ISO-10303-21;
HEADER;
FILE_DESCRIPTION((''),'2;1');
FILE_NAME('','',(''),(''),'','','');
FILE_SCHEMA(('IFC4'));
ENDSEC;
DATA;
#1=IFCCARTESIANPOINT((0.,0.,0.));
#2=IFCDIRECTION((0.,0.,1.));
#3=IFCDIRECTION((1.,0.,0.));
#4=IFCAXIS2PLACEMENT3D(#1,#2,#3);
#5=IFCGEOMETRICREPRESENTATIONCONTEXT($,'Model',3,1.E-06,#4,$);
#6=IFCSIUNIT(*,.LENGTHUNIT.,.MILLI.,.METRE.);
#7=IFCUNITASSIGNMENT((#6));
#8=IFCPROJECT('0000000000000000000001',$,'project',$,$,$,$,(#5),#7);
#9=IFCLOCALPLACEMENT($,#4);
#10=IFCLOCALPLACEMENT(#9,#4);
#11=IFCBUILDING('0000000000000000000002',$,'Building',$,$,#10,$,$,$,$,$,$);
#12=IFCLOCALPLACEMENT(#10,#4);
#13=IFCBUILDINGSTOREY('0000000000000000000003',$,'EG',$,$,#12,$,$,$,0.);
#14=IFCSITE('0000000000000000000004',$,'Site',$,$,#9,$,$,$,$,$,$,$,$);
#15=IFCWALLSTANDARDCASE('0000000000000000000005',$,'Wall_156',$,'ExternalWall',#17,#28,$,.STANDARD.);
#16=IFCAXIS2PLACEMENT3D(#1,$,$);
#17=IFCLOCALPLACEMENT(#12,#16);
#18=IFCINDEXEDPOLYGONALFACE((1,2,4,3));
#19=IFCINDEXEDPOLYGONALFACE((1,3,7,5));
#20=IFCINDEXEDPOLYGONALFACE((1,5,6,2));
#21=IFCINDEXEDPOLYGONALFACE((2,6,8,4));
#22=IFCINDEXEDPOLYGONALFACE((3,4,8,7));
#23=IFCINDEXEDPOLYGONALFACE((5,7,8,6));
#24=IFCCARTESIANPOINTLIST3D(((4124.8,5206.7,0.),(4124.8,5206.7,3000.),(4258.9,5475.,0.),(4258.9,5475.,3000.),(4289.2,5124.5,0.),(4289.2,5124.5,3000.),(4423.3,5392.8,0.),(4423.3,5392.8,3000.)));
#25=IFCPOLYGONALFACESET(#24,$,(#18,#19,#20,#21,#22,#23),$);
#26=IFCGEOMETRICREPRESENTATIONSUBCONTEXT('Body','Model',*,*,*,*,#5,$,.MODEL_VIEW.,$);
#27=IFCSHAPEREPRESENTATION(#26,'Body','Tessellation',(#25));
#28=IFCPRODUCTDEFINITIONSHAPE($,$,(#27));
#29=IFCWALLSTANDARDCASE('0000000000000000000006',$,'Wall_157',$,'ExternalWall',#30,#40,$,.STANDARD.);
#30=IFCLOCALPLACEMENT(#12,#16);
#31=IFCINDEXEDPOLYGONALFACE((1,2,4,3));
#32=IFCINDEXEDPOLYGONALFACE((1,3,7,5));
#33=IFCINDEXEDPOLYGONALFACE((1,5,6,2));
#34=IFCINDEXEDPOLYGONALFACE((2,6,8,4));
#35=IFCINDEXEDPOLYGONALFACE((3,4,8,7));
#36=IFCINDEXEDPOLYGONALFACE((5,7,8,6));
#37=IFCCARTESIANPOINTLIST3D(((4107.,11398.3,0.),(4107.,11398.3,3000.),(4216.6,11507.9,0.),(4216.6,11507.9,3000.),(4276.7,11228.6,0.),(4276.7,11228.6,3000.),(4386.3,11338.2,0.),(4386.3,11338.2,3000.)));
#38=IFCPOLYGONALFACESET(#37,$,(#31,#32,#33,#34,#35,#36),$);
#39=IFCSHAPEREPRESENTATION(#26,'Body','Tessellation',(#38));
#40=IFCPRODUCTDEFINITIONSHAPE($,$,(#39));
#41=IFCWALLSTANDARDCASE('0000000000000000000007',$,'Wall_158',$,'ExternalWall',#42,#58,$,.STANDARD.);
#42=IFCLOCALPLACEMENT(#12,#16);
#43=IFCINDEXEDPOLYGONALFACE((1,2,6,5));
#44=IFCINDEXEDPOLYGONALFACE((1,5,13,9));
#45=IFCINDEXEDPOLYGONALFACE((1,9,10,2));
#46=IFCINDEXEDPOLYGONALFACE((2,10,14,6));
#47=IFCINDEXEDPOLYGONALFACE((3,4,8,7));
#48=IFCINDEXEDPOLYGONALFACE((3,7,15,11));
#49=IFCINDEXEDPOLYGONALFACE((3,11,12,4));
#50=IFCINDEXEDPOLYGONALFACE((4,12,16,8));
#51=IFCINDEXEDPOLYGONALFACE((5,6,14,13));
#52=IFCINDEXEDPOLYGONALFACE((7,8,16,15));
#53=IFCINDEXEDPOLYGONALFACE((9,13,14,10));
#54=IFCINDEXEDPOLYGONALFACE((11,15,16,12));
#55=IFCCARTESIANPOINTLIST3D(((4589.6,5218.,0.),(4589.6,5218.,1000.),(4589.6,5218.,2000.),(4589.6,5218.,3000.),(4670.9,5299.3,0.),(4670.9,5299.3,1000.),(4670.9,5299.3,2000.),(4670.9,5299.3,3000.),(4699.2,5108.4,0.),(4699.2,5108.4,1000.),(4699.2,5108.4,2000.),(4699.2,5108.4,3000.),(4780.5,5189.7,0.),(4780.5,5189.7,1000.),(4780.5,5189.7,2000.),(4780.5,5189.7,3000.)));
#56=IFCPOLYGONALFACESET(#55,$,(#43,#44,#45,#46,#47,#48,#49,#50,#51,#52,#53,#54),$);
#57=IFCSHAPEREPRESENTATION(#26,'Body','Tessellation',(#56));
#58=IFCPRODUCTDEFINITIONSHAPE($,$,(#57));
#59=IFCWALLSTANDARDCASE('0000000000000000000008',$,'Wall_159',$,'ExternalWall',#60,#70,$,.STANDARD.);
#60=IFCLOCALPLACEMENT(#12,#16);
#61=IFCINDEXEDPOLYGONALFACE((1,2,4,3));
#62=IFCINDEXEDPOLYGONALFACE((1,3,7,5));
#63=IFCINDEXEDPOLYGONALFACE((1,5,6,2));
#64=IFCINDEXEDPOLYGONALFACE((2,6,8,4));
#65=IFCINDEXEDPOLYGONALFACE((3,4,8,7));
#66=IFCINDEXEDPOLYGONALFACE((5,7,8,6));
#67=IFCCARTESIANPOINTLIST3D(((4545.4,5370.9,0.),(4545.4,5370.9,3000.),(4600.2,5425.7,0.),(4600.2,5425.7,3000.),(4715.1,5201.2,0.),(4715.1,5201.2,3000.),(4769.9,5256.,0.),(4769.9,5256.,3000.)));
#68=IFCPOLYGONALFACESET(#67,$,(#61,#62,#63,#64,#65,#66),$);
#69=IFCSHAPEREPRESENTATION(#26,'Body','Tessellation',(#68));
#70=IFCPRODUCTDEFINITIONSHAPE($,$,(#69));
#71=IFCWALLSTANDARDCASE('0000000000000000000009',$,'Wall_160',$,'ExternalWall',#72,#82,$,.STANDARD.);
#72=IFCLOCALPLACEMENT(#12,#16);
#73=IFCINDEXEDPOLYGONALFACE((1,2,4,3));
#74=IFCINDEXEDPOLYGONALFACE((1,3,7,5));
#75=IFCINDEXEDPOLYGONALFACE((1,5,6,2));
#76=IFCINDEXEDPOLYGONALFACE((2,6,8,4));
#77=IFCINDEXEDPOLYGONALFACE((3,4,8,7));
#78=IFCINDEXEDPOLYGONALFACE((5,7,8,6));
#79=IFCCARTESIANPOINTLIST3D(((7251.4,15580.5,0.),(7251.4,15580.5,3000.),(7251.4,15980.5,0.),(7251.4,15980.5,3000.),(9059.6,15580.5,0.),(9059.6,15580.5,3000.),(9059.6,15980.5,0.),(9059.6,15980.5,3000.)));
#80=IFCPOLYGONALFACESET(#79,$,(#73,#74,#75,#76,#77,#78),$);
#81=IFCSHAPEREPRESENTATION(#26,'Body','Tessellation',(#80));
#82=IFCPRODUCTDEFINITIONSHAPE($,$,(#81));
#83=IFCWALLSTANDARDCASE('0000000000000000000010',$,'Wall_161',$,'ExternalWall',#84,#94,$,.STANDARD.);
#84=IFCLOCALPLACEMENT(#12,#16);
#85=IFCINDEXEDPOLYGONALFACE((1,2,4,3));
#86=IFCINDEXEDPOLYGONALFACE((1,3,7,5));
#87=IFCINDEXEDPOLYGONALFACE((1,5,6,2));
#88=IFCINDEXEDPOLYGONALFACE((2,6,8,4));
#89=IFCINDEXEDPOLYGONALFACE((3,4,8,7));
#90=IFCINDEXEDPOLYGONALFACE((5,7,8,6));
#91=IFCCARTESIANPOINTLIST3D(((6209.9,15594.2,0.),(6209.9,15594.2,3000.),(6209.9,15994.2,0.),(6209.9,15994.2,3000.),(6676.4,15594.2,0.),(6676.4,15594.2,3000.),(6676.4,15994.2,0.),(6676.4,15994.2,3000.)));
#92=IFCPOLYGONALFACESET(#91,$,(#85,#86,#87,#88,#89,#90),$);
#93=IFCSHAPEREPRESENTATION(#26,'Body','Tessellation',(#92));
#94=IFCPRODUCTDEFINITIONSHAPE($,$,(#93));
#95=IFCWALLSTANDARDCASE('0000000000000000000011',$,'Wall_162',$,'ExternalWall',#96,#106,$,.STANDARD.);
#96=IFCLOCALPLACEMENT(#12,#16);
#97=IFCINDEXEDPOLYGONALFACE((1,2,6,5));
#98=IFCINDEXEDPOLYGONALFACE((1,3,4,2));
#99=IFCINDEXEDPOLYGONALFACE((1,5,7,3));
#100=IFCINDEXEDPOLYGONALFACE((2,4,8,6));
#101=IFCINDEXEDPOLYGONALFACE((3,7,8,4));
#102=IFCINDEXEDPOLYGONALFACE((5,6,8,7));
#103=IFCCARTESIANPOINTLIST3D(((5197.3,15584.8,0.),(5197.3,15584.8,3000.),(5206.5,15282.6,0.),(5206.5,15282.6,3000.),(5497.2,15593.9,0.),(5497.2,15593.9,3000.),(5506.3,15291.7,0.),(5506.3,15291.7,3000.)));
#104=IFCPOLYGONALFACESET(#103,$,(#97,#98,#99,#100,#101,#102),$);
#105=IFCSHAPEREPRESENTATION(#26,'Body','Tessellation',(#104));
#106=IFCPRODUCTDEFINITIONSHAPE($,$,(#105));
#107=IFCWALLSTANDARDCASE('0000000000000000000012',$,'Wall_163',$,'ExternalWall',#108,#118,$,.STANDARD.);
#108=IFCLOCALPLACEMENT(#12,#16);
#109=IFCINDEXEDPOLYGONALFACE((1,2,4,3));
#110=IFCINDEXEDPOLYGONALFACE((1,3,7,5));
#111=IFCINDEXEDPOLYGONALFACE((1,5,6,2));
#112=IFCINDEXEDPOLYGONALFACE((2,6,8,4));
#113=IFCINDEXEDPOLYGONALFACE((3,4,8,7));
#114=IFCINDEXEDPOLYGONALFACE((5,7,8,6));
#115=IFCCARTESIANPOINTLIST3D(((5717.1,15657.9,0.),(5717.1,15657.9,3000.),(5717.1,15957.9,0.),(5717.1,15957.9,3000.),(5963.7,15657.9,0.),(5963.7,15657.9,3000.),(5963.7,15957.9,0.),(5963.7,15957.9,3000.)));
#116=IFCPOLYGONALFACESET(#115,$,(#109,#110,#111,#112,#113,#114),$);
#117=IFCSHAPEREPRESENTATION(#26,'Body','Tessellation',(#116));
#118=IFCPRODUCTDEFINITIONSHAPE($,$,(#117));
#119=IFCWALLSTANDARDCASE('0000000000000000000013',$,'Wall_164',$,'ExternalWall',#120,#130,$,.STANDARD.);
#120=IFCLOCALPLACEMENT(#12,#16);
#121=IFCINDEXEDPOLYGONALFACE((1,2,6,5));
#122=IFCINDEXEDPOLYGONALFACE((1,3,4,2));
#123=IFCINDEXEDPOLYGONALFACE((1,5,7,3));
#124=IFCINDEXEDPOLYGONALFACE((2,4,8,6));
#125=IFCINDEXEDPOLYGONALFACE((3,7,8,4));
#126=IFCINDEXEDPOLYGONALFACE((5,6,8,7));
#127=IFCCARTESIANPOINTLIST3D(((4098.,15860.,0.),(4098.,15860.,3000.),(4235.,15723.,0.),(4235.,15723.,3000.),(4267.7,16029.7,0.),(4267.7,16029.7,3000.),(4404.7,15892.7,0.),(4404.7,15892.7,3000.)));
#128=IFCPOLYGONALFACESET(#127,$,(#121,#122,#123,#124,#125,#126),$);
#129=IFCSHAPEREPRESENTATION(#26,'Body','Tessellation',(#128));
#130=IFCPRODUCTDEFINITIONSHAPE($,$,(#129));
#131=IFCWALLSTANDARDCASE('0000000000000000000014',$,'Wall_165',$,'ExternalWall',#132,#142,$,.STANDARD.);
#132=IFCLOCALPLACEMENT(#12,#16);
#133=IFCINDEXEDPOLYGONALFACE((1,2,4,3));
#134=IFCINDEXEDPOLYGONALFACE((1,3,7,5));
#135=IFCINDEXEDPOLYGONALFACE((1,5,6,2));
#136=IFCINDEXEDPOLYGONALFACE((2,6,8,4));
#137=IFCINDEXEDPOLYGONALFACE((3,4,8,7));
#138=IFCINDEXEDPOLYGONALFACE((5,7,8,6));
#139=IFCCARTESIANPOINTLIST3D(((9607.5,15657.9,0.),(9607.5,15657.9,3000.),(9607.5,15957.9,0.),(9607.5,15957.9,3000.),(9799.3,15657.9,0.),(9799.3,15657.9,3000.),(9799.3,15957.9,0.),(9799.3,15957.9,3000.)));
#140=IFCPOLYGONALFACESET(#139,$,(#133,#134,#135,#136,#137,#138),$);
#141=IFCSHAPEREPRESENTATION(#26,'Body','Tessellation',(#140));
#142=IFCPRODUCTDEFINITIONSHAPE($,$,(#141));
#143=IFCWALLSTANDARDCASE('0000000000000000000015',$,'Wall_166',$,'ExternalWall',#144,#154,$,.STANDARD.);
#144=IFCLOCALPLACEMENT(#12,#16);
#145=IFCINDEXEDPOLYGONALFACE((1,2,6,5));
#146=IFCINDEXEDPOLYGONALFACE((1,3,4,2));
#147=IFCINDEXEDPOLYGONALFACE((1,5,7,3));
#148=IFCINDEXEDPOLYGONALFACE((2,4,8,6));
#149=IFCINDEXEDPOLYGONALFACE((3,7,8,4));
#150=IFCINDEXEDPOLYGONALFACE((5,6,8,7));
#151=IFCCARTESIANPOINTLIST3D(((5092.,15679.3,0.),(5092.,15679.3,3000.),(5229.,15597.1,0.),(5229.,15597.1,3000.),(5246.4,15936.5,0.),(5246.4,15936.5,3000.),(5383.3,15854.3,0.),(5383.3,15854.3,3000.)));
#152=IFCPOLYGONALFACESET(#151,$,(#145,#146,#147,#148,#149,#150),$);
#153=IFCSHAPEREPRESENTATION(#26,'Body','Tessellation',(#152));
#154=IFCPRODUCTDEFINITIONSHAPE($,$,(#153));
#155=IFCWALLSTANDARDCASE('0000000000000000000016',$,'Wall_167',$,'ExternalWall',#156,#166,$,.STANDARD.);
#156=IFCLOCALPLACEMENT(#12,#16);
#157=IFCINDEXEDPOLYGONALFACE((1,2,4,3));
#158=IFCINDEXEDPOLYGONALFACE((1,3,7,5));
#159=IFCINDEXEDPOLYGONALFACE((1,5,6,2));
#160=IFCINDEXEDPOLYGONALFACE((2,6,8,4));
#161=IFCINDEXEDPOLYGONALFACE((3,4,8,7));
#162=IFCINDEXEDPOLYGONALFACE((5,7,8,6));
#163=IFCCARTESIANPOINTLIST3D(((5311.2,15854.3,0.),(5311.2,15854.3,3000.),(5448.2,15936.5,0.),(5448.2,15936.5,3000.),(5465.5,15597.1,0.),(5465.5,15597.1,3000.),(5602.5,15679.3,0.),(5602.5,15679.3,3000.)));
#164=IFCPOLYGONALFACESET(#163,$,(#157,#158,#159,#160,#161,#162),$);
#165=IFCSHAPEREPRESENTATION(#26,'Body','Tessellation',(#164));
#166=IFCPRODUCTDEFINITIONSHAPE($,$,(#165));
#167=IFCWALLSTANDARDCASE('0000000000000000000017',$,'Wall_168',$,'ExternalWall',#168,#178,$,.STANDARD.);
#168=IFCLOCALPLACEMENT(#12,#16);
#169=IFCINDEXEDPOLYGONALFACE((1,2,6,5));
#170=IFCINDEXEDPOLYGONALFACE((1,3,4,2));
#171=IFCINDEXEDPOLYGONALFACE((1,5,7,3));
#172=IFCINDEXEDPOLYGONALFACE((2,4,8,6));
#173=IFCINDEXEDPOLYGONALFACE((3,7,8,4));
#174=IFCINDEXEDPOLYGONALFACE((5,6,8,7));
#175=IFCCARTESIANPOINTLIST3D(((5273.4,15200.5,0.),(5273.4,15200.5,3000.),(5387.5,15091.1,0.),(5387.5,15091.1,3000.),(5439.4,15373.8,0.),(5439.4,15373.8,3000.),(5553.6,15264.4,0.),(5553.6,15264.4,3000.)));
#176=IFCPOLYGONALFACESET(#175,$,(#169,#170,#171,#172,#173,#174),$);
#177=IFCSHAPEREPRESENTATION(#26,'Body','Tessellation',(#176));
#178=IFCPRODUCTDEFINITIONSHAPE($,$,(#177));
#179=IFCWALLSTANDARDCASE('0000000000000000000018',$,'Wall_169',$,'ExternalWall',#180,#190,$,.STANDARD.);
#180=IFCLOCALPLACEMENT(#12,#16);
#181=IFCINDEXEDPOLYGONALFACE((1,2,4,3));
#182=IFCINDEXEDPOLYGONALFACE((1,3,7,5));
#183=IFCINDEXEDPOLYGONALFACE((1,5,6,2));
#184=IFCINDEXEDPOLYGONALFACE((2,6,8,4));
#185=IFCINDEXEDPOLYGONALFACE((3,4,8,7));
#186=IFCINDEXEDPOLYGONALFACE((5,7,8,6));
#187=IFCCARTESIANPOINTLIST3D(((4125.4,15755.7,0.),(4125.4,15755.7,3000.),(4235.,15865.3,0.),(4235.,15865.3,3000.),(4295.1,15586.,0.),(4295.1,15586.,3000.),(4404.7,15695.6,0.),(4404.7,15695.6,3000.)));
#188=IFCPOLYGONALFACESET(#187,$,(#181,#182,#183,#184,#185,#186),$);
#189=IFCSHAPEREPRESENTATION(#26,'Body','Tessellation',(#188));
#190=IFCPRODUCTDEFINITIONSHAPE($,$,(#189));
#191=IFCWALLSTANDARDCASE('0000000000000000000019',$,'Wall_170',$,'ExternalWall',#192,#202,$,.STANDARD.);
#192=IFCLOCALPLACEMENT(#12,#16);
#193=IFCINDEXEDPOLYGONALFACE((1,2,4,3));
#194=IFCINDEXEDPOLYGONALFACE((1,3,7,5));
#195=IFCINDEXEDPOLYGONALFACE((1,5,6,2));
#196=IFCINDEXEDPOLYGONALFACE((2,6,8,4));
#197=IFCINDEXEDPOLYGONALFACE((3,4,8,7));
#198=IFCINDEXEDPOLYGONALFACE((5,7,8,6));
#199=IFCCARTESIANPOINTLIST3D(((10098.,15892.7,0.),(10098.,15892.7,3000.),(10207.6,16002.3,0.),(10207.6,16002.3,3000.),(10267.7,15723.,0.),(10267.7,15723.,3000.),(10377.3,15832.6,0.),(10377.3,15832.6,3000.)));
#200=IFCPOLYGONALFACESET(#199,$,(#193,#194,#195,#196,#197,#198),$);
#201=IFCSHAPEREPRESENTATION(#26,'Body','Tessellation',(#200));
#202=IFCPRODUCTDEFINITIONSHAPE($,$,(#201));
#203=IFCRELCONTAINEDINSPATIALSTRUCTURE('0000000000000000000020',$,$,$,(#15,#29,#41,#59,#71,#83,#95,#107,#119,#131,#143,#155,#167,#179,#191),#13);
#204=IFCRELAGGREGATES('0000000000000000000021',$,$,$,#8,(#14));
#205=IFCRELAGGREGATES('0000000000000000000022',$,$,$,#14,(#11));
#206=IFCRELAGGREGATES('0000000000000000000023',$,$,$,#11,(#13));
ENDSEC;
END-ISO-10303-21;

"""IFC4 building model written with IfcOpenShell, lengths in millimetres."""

from ifc_helpers import new_model, si_unit, frame, origin_with_axes, place, context, subcontext, project, spatial, rectangle, extrude, element, save


model = new_model("IFC4")

# Units and contexts
model_context = context("Model", 3, precision=1e-06, world=origin_with_axes())
body_context = subcontext(model_context, "Body", "Model", "MODEL_VIEW")
ifc_project = project(units=[si_unit("LENGTHUNIT", "METRE", prefix="MILLI")], contexts=[model_context])

# Site, building, storey
site_placement = place(None, origin_with_axes())
site = spatial("IfcSite", under=ifc_project, at=site_placement, Name="Site")
building_placement = place(site_placement, origin_with_axes())
building = spatial("IfcBuilding", under=site, at=building_placement, Name="Building")
storey_placement = place(building_placement, origin_with_axes())
storey = spatial("IfcBuildingStorey", under=building, at=storey_placement, Name="EG", Elevation=0.0)

# Walls
wall_1_placement = place(storey_placement, origin_with_axes())
element("IfcWallStandardCase", 1, at=wall_1_placement, inside=storey, Name="Wall_156", ObjectType="ExternalWall", PredefinedType="STANDARD", context=body_context, shape_type="SweptSolid", body=[
    extrude(rectangle(XDim=183.8, YDim=300.0), frame((4274.1, 5299.7, 0.0), z_axis=(0.0, 0.0, 1.0), x_axis=(-0.894427, 0.447214, 0.0)), (0.0, 0.0, 1.0), 3000.0),
])
wall_2_placement = place(storey_placement, origin_with_axes())
element("IfcWallStandardCase", 2, at=wall_2_placement, inside=storey, Name="Wall_157", ObjectType="ExternalWall", PredefinedType="STANDARD", context=body_context, shape_type="SweptSolid", body=[
    extrude(rectangle(XDim=155.0, YDim=240.0), frame((4246.7, 11368.2, 0.0), z_axis=(0.0, 0.0, 1.0), x_axis=(0.707107, 0.707107, 0.0)), (0.0, 0.0, 1.0), 3000.0),
])

# Wall, opening
wall_3_placement = place(storey_placement, origin_with_axes())
wall_3 = element("IfcWallStandardCase", 3, at=wall_3_placement, inside=storey, Name="Wall_158", ObjectType="ExternalWall", PredefinedType="STANDARD", context=body_context, shape_type="SweptSolid", body=[
    extrude(rectangle(XDim=155.0, YDim=115.0), frame((4685.0, 5203.9, 0.0), z_axis=(0.0, 0.0, 1.0), x_axis=(0.707107, -0.707107, 0.0)), (0.0, 0.0, 1.0), 3000.0),
])
opening_1_placement = place(wall_3_placement, origin_with_axes())
element("IfcOpeningElement", 4, at=opening_1_placement, inside=storey, cuts=wall_3, context=body_context, shape_type="SweptSolid", body=[
    extrude(rectangle(XDim=2418.9, YDim=115.0), frame((5473.2, 4415.6, 1000.0), z_axis=(0.0, 0.0, 1.0), x_axis=(0.707107, -0.707107, 0.0)), (0.0, 0.0, 1.0), 1000.0),
])

# Walls
wall_4_placement = place(storey_placement, origin_with_axes())
element("IfcWallStandardCase", 5, at=wall_4_placement, inside=storey, Name="Wall_159", ObjectType="ExternalWall", PredefinedType="STANDARD", context=body_context, shape_type="SweptSolid", body=[
    extrude(rectangle(XDim=77.5, YDim=240.0), frame((4657.6, 5313.4, 0.0), z_axis=(0.0, 0.0, 1.0), x_axis=(0.707107, 0.707107, 0.0)), (0.0, 0.0, 1.0), 3000.0),
])
wall_5_placement = place(storey_placement, origin_with_axes())
element("IfcWallStandardCase", 6, at=wall_5_placement, inside=storey, Name="Wall_160", ObjectType="ExternalWall", PredefinedType="STANDARD", context=body_context, shape_type="SweptSolid", body=[
    extrude(rectangle(XDim=1808.2, YDim=400.0), frame((8155.5, 15780.5, 0.0), z_axis=(0.0, 0.0, 1.0), x_axis=(1.0, 0.0, 0.0)), (0.0, 0.0, 1.0), 3000.0),
])
wall_6_placement = place(storey_placement, origin_with_axes())
element("IfcWallStandardCase", 7, at=wall_6_placement, inside=storey, Name="Wall_161", ObjectType="ExternalWall", PredefinedType="STANDARD", context=body_context, shape_type="SweptSolid", body=[
    extrude(rectangle(XDim=466.6, YDim=400.0), frame((6443.2, 15794.2, 0.0), z_axis=(0.0, 0.0, 1.0), x_axis=(1.0, 0.0, 0.0)), (0.0, 0.0, 1.0), 3000.0),
])
wall_7_placement = place(storey_placement, origin_with_axes())
element("IfcWallStandardCase", 8, at=wall_7_placement, inside=storey, Name="Wall_162", ObjectType="ExternalWall", PredefinedType="STANDARD", context=body_context, shape_type="SweptSolid", body=[
    extrude(rectangle(XDim=302.3, YDim=300.0), frame((5351.8, 15438.2, 0.0), z_axis=(0.0, 0.0, 1.0), x_axis=(0.030206, -0.999544, 0.0)), (0.0, 0.0, 1.0), 3000.0),
])
wall_8_placement = place(storey_placement, origin_with_axes())
element("IfcWallStandardCase", 9, at=wall_8_placement, inside=storey, Name="Wall_163", ObjectType="ExternalWall", PredefinedType="STANDARD", context=body_context, shape_type="SweptSolid", body=[
    extrude(rectangle(XDim=246.6, YDim=300.0), frame((5840.4, 15807.9, 0.0), z_axis=(0.0, 0.0, 1.0), x_axis=(1.0, 0.0, 0.0)), (0.0, 0.0, 1.0), 3000.0),
])
wall_9_placement = place(storey_placement, origin_with_axes())
element("IfcWallStandardCase", 10, at=wall_9_placement, inside=storey, Name="Wall_164", ObjectType="ExternalWall", PredefinedType="STANDARD", context=body_context, shape_type="SweptSolid", body=[
    extrude(rectangle(XDim=193.7, YDim=240.0), frame((4251.4, 15876.4, 0.0), z_axis=(0.0, 0.0, 1.0), x_axis=(-0.707107, 0.707107, 0.0)), (0.0, 0.0, 1.0), 3000.0),
])
wall_10_placement = place(storey_placement, origin_with_axes())
element("IfcWallStandardCase", 11, at=wall_10_placement, inside=storey, Name="Wall_165", ObjectType="ExternalWall", PredefinedType="STANDARD", context=body_context, shape_type="SweptSolid", body=[
    extrude(rectangle(XDim=191.8, YDim=300.0), frame((9703.4, 15807.9, 0.0), z_axis=(0.0, 0.0, 1.0), x_axis=(1.0, 0.0, 0.0)), (0.0, 0.0, 1.0), 3000.0),
])
wall_11_placement = place(storey_placement, origin_with_axes())
element("IfcWallStandardCase", 12, at=wall_11_placement, inside=storey, Name="Wall_166", ObjectType="ExternalWall", PredefinedType="STANDARD", context=body_context, shape_type="SweptSolid", body=[
    extrude(rectangle(XDim=159.8, YDim=300.0), frame((5237.7, 15766.8, 0.0), z_axis=(0.0, 0.0, 1.0), x_axis=(0.857493, -0.514496, 0.0)), (0.0, 0.0, 1.0), 3000.0),
])
wall_12_placement = place(storey_placement, origin_with_axes())
element("IfcWallStandardCase", 13, at=wall_12_placement, inside=storey, Name="Wall_167", ObjectType="ExternalWall", PredefinedType="STANDARD", context=body_context, shape_type="SweptSolid", body=[
    extrude(rectangle(XDim=159.8, YDim=300.0), frame((5456.8, 15766.8, 0.0), z_axis=(0.0, 0.0, 1.0), x_axis=(0.857493, 0.514496, 0.0)), (0.0, 0.0, 1.0), 3000.0),
])
wall_13_placement = place(storey_placement, origin_with_axes())
element("IfcWallStandardCase", 14, at=wall_13_placement, inside=storey, Name="Wall_168", ObjectType="ExternalWall", PredefinedType="STANDARD", context=body_context, shape_type="SweptSolid", body=[
    extrude(rectangle(XDim=158.1, YDim=240.0), frame((5413.5, 15232.4, 0.0), z_axis=(0.0, 0.0, 1.0), x_axis=(0.722042, -0.69185, 0.0)), (0.0, 0.0, 1.0), 3000.0),
])
wall_14_placement = place(storey_placement, origin_with_axes())
element("IfcWallStandardCase", 15, at=wall_14_placement, inside=storey, Name="Wall_169", ObjectType="ExternalWall", PredefinedType="STANDARD", context=body_context, shape_type="SweptSolid", body=[
    extrude(rectangle(XDim=155.0, YDim=240.0), frame((4265.1, 15725.7, 0.0), z_axis=(0.0, 0.0, 1.0), x_axis=(-0.707107, -0.707107, 0.0)), (0.0, 0.0, 1.0), 3000.0),
])
wall_15_placement = place(storey_placement, origin_with_axes())
element("IfcWallStandardCase", 16, at=wall_15_placement, inside=storey, Name="Wall_170", ObjectType="ExternalWall", PredefinedType="STANDARD", context=body_context, shape_type="SweptSolid", body=[
    extrude(rectangle(XDim=155.0, YDim=240.0), frame((10237.7, 15862.7, 0.0), z_axis=(0.0, 0.0, 1.0), x_axis=(0.707107, 0.707107, 0.0)), (0.0, 0.0, 1.0), 3000.0),
])

save(model, "model.ifc")
